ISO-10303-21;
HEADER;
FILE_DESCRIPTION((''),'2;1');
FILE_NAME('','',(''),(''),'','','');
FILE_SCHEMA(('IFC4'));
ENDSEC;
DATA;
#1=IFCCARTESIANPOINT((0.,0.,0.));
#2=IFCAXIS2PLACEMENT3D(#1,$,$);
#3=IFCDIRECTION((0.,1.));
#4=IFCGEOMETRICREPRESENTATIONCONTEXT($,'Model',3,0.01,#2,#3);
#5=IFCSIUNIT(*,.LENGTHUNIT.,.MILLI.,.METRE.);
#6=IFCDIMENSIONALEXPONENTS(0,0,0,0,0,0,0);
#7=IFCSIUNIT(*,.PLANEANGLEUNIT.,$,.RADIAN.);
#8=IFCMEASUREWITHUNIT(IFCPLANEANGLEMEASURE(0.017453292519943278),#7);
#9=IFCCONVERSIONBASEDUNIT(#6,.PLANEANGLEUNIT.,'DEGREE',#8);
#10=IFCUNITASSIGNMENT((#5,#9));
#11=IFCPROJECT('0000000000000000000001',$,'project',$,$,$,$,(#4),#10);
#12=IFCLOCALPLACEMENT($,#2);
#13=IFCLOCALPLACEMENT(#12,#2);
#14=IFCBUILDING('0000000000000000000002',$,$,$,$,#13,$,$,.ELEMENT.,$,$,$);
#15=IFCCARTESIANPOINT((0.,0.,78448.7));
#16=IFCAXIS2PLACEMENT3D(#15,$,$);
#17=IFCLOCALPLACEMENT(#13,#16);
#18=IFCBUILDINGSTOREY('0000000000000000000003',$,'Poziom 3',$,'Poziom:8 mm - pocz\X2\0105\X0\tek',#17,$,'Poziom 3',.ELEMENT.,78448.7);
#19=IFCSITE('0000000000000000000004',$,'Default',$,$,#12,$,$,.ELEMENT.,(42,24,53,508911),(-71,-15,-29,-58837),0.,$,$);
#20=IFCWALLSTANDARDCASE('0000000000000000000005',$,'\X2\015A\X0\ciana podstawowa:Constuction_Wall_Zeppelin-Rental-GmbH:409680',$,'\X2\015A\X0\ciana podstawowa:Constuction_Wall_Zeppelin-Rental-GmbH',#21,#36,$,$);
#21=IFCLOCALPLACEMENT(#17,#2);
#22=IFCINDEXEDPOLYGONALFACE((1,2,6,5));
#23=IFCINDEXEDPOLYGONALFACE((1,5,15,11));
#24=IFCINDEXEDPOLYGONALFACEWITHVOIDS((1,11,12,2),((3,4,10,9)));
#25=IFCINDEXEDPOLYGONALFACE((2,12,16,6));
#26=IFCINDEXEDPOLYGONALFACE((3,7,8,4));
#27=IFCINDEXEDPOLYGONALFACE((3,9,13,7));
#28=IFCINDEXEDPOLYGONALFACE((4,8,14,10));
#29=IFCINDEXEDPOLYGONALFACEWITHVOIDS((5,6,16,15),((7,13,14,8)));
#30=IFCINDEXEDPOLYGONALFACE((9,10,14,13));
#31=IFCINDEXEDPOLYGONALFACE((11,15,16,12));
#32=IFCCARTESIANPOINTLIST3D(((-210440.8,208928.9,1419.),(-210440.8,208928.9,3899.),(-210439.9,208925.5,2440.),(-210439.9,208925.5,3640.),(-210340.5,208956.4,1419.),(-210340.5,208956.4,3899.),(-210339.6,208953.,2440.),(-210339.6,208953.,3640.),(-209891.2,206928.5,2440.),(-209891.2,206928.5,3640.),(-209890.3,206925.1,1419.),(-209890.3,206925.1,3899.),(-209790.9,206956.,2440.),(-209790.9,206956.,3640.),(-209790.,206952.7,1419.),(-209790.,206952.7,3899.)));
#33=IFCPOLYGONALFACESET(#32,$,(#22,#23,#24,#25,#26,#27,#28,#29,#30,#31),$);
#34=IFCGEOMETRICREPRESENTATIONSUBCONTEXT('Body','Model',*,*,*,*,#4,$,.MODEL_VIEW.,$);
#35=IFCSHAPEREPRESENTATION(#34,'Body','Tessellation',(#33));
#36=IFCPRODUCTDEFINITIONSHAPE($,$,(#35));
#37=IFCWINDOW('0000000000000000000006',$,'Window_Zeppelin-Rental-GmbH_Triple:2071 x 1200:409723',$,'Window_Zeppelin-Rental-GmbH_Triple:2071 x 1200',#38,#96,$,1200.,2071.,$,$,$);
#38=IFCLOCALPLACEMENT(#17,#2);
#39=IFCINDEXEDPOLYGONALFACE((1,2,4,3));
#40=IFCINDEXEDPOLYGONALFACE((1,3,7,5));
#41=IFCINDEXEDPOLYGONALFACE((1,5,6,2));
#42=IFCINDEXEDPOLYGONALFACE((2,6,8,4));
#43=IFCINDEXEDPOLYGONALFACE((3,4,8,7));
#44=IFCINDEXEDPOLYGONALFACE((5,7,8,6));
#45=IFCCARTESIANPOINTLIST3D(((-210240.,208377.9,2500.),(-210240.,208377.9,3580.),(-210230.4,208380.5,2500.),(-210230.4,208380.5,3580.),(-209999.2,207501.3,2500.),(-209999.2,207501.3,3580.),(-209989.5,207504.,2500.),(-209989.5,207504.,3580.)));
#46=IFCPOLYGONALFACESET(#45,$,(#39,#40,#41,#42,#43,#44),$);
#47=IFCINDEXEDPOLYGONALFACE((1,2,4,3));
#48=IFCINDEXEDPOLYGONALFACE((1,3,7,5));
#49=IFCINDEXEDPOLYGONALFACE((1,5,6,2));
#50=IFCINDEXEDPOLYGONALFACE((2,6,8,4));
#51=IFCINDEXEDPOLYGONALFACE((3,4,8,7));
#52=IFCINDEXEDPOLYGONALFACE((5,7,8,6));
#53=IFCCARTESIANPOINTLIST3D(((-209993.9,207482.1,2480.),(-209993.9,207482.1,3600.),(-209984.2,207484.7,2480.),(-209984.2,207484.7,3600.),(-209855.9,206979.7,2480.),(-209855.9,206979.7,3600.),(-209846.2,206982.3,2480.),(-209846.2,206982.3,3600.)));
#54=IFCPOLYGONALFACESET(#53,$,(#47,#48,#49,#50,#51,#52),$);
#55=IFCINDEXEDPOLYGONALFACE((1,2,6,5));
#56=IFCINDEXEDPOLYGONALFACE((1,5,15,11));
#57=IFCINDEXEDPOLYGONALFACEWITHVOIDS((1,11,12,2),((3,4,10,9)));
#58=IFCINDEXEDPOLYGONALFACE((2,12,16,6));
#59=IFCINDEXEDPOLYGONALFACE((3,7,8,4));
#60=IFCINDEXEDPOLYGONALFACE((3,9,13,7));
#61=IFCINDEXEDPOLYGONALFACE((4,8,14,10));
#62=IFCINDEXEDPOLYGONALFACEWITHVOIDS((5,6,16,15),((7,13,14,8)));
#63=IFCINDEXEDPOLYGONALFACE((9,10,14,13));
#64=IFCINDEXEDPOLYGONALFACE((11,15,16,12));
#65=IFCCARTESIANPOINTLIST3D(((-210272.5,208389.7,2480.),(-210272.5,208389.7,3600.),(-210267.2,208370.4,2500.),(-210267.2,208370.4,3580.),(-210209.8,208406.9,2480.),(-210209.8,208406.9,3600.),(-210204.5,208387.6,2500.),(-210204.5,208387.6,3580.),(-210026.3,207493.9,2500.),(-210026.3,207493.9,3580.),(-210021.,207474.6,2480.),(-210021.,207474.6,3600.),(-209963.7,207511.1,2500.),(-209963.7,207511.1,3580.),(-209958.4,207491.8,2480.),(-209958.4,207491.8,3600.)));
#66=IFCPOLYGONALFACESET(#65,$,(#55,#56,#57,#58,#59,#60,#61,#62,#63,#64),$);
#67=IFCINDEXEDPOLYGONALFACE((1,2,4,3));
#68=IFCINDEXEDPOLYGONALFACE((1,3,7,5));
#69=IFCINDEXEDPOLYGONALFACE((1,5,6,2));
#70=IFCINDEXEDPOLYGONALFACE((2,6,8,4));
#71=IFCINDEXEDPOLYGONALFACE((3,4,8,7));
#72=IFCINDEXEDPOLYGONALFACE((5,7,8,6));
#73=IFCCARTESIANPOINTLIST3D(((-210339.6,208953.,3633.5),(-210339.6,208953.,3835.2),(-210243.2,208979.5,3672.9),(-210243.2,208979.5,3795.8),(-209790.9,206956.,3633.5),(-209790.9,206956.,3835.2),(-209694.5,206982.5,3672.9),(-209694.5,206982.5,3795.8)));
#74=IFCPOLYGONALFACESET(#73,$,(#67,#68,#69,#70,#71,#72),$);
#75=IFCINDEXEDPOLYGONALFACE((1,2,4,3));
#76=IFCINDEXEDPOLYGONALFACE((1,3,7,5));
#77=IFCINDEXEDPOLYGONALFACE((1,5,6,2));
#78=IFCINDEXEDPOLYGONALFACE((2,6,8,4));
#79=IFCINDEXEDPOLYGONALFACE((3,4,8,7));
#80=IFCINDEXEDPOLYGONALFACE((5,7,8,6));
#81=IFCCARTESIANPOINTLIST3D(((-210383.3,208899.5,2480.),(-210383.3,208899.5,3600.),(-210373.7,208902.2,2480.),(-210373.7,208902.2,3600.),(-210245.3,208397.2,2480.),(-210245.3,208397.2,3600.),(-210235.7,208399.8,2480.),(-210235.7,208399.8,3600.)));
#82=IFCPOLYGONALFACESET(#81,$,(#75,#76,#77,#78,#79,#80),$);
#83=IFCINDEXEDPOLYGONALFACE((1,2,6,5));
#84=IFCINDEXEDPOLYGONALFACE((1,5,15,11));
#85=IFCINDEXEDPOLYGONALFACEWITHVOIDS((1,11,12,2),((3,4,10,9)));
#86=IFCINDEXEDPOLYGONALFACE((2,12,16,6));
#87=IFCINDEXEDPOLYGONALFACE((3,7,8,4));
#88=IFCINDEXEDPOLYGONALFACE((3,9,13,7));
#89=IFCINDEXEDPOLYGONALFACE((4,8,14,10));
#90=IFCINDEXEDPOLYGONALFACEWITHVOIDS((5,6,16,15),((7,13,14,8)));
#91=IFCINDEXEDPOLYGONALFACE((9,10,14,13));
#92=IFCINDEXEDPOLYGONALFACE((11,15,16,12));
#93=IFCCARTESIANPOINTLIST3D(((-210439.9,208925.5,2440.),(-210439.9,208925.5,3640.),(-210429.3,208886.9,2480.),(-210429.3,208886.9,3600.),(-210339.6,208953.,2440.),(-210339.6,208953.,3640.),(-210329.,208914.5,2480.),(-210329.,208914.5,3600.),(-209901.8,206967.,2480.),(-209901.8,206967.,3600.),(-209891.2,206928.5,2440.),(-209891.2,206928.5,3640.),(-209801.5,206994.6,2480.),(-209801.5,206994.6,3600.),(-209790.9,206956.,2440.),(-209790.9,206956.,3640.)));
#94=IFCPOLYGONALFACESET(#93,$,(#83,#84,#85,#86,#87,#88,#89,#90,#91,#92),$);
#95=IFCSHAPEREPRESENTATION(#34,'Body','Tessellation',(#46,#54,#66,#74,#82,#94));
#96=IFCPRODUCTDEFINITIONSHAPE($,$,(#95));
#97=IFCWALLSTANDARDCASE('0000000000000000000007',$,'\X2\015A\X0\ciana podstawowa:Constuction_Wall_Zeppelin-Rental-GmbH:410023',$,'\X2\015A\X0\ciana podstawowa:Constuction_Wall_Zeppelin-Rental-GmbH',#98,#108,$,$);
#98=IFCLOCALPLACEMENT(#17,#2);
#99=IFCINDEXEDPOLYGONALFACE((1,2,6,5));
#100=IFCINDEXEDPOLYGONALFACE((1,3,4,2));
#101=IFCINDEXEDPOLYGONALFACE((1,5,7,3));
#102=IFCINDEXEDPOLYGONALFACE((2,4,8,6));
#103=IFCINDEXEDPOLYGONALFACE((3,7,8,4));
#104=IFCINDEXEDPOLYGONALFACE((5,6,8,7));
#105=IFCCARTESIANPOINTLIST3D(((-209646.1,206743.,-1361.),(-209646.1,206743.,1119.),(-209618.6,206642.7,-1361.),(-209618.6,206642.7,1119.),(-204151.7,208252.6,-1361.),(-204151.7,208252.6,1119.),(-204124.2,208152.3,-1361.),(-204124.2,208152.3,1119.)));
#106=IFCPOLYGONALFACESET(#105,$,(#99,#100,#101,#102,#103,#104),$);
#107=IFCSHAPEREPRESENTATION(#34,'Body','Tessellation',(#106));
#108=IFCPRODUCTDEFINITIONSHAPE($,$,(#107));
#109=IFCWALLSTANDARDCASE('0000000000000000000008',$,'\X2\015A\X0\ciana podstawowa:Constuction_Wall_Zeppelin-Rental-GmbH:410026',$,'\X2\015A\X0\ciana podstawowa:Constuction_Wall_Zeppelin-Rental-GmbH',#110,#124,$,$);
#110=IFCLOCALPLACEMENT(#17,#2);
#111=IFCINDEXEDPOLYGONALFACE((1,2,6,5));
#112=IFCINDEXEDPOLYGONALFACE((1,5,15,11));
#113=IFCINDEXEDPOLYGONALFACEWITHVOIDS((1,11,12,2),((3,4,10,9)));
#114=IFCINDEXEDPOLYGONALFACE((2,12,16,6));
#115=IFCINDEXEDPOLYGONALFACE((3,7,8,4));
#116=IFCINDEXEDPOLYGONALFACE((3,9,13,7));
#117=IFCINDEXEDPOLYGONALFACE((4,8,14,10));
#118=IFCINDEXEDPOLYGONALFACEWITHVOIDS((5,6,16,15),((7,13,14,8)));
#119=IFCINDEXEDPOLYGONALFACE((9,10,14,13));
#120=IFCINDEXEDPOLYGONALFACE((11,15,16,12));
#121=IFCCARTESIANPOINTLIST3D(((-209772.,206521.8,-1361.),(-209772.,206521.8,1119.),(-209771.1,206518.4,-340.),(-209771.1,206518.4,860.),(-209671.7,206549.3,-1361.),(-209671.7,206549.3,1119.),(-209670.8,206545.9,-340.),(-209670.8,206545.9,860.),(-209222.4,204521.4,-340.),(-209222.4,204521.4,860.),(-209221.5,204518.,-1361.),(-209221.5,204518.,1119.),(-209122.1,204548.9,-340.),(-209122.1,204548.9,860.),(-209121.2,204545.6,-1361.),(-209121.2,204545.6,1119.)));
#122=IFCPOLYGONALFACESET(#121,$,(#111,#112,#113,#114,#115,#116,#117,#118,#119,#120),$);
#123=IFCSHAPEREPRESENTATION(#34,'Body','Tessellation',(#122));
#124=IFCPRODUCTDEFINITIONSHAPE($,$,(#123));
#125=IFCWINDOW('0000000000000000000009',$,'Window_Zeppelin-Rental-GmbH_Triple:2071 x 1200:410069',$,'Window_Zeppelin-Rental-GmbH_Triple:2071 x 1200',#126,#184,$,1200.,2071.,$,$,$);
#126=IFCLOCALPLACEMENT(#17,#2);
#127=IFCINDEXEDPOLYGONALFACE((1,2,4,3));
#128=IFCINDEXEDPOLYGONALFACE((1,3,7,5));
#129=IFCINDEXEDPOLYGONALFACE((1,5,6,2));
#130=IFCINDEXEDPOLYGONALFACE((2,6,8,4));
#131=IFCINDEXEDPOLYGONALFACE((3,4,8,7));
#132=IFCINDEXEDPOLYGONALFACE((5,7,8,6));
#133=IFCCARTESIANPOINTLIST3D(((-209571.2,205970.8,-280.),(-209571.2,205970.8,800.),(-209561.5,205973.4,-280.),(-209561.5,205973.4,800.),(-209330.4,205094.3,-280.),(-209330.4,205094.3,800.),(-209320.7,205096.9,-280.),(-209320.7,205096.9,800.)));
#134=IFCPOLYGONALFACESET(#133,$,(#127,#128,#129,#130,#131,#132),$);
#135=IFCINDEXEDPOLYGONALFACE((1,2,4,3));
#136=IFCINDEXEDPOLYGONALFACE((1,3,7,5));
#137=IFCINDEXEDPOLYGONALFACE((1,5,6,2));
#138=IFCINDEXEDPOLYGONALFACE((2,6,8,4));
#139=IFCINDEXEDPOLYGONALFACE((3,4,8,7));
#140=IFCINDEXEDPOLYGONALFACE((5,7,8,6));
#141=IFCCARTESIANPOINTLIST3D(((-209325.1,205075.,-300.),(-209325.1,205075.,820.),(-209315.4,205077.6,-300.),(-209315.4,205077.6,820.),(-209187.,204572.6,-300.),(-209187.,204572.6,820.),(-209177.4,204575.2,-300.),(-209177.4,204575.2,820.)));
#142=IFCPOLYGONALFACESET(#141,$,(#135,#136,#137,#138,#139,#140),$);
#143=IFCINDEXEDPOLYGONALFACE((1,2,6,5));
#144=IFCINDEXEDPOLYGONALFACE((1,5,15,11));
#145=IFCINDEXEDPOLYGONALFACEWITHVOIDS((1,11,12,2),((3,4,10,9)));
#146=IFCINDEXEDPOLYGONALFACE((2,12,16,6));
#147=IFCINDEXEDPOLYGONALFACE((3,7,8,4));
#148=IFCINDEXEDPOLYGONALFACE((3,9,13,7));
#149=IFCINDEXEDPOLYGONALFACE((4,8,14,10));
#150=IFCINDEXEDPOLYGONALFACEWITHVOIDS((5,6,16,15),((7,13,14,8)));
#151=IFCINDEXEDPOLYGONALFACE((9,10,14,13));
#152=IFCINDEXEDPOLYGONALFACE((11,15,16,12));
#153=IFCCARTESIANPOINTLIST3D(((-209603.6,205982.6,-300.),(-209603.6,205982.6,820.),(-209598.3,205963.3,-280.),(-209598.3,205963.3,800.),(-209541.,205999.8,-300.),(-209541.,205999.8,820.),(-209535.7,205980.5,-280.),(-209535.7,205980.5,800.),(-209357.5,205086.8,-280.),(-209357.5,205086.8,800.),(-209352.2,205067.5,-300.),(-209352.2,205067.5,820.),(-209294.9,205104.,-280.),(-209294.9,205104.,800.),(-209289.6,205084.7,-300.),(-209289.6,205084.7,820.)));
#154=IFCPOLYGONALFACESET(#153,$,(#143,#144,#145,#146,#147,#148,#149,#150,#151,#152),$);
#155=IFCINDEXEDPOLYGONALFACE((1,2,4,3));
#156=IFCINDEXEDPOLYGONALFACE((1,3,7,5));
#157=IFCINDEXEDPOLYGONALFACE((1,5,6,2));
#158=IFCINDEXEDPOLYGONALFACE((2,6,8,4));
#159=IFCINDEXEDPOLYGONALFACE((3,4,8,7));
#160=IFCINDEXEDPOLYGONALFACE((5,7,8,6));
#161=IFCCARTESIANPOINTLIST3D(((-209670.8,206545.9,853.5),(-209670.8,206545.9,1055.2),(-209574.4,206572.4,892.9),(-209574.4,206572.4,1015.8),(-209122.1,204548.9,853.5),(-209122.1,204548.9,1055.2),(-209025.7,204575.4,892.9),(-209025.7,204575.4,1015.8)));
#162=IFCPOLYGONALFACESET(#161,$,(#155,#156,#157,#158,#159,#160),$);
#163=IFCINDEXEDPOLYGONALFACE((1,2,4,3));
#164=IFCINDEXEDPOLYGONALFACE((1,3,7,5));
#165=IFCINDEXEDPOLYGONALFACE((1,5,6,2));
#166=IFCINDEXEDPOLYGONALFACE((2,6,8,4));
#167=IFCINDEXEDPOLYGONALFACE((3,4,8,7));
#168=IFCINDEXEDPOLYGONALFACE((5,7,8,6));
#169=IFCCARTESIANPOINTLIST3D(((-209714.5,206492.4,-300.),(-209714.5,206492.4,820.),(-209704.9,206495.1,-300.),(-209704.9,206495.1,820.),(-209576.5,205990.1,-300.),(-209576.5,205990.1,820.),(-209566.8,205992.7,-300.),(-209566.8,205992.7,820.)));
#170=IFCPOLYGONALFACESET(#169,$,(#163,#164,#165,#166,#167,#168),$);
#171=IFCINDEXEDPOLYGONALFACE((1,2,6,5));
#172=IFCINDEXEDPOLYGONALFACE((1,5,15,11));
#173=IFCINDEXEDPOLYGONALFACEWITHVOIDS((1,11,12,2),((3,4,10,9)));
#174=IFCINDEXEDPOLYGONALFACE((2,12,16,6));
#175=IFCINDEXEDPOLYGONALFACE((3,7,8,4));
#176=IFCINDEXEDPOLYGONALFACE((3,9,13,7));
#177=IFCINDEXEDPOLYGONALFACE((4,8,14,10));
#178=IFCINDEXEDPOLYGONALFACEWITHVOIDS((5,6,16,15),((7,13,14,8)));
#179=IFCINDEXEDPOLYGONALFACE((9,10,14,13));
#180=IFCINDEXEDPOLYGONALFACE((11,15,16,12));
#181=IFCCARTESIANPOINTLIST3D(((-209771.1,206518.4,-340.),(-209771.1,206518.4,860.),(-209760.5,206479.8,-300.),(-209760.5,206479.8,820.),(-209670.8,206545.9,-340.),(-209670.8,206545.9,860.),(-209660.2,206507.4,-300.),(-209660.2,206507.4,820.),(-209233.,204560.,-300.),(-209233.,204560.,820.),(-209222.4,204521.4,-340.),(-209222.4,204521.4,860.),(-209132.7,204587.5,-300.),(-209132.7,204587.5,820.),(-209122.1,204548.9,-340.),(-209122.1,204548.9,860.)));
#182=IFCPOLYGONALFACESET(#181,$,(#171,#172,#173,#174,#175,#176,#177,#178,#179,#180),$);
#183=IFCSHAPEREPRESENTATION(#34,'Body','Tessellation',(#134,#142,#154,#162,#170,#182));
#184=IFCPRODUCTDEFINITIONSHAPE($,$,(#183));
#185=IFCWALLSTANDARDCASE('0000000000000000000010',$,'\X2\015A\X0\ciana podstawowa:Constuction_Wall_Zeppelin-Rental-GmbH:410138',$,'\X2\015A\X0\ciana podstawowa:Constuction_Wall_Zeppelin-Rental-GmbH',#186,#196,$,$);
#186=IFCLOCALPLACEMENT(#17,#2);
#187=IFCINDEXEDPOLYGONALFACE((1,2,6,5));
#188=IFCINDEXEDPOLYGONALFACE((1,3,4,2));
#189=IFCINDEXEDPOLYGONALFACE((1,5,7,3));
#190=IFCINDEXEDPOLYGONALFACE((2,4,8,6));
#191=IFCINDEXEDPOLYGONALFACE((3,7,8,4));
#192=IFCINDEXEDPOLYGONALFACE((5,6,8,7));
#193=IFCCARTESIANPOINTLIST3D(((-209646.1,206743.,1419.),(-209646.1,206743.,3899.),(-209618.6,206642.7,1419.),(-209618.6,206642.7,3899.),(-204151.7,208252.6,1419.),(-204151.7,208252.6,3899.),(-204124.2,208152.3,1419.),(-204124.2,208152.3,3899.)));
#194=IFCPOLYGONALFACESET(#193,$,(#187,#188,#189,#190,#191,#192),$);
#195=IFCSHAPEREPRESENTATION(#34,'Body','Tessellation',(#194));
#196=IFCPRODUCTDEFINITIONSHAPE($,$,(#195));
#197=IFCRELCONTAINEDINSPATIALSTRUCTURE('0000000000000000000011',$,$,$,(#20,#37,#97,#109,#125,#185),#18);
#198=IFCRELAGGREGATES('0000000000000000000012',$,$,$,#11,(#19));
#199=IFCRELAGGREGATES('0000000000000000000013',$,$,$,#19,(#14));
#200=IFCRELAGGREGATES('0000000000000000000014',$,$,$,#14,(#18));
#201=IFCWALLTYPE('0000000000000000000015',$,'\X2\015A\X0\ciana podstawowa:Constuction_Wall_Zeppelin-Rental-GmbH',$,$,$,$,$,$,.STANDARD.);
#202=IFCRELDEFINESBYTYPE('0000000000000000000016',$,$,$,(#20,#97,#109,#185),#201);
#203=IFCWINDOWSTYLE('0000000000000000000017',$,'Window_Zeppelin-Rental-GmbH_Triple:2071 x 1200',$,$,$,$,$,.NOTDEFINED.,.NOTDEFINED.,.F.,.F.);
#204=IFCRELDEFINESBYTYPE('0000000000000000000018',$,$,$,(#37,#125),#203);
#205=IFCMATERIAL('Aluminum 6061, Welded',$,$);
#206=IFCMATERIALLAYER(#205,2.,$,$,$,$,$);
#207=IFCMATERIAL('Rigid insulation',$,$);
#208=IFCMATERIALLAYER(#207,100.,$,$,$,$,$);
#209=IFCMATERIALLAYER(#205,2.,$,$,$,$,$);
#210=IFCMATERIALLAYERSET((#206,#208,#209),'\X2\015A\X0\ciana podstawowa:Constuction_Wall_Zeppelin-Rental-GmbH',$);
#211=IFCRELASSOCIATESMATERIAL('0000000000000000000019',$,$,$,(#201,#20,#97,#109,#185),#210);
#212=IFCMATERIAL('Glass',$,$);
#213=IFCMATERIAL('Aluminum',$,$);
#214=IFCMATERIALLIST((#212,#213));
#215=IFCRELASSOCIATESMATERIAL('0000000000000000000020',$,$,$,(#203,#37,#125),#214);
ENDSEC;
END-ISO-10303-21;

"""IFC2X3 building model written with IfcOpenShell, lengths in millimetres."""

from ifc_helpers import new_model, entity, si_unit, converted_unit, direction, frame, frame_2d, origin, origin_2d_with_axis, place, context, subcontext, project, spatial, polyline, rectangle, outline, extrude, source, transform, mapped, material, material_list, layer, layer_set, layer_usage, type_object, type_shapes, element, fill, save


model = new_model("IFC2X3")

# Units and contexts
model_context = context("Model", 3, precision=0.01, world=origin(), true_north=direction((0.0, 1.0)))
body_context = subcontext(model_context, "Body", "Model", "MODEL_VIEW")
ifc_project = project(units=[si_unit("LENGTHUNIT", "METRE", prefix="MILLI"), converted_unit("PLANEANGLEUNIT", "DEGREE", entity("IfcPlaneAngleMeasure", 0.017453292519943278), si_unit("PLANEANGLEUNIT", "RADIAN"), dimensions=[0, 0, 0, 0, 0, 0, 0])], contexts=[model_context])

# Site, building, storey
site_placement = place(None, origin())
site = spatial("IfcSite", under=ifc_project, at=site_placement, Name="Default", CompositionType="ELEMENT", RefLatitude=(42, 24, 53, 508911), RefLongitude=(-71, -15, -29, -58837), RefElevation=0.0)
building_placement = place(site_placement, origin())
building = spatial("IfcBuilding", under=site, at=building_placement, CompositionType="ELEMENT")
storey_placement = place(building_placement, frame((0.0, 0.0, 78448.7)))
storey = spatial("IfcBuildingStorey", under=building, at=storey_placement, Name="Poziom 3", ObjectType="Poziom:8 mm - początek", LongName="Poziom 3", CompositionType="ELEMENT", Elevation=78448.7)

# Shared definitions
ifc_material_1 = material(Name="Aluminum 6061, Welded")
ifc_layer_1 = layer(ifc_material_1, 2.0)
ifc_material_2 = material(Name="Rigid insulation")
ifc_layer_2 = layer(ifc_material_2, 100.0)
ifc_layer_3 = layer(ifc_material_1, 2.0)
ifc_layer_set_1 = layer_set([ifc_layer_1, ifc_layer_2, ifc_layer_3], Name="Ściana podstawowa:Constuction_Wall_Zeppelin-Rental-GmbH")
wall_type_1 = type_object("IfcWallType", Name="Ściana podstawowa:Constuction_Wall_Zeppelin-Rental-GmbH", PredefinedType="STANDARD", material=ifc_layer_set_1)

# Shared definitions
ifc_material_3 = material(Name="Glass")
ifc_material_4 = material(Name="Aluminum")
ifc_material_list = material_list([ifc_material_3, ifc_material_4])
window_style = type_object("IfcWindowStyle", Name="Window_Zeppelin-Rental-GmbH_Triple:2071 x 1200", ConstructionType="NOTDEFINED", OperationType="NOTDEFINED", ParameterTakesPrecedence=False, Sizeable=False, material=ifc_material_list)
shared_shape_1 = source(origin(), body_context, "Body", "SweptSolid", [
    extrude(rectangle(XDim=10.0, YDim=909.0, at=origin_2d_with_axis()), frame((1035.5, 52.7, 60.0), z_axis=(0.0, 0.0, 1.0), x_axis=(0.0, -1.0, 0.0)), (0.0, 0.0, 1.0), 1080.0),
    extrude(rectangle(XDim=521.0, YDim=10.0, at=frame_2d((0.0, 0.0), x_axis=(1.0, 0.0))), frame((300.5, 52.7, 40.0), z_axis=(0.0, 0.0, 1.0), x_axis=(-1.0, 0.0, 0.0)), (0.0, 0.0, 1.0), 1120.0),
    extrude(outline(polyline([(-474.5, -560.0), (474.5, -560.0), (474.5, 560.0), (-474.5, 560.0), (-474.5, -560.0)]), holes=[polyline([(-454.5, 540.0), (454.5, 540.0), (454.5, -540.0), (-454.5, -540.0), (-454.5, 540.0)])]), frame((1035.5, 85.8, 600.0), z_axis=(0.0, -1.0, 0.0), x_axis=(1.0, 0.0, 0.0)), (0.0, 0.0, 1.0), 65.0),
    extrude(outline(polyline([(-24.0, -75.5), (83.5, -75.5), (9.6, 112.1), (-69.0, 38.9), (-24.0, -75.5)])), frame((2071.0, -48.7, 1294.4), z_axis=(-1.0, 0.0, 0.0), x_axis=(0.0, 0.930458, 0.366398)), (0.0, 0.0, 1.0), 2071.0),
    extrude(rectangle(XDim=10.0, YDim=521.0, at=frame_2d((0.0, 0.0), x_axis=(1.0, 0.0))), frame((1770.5, 52.7, 40.0), z_axis=(0.0, 0.0, 1.0), x_axis=(0.0, -1.0, 0.0)), (0.0, 0.0, 1.0), 1120.0),
    extrude(outline(polyline([(-1035.5, -600.0), (1035.5, -600.0), (1035.5, 600.0), (-1035.5, 600.0), (-1035.5, -600.0)]), holes=[polyline([(-995.5, 560.0), (995.5, 560.0), (995.5, -560.0), (-995.5, -560.0), (-995.5, 560.0)])]), frame((1035.5, 105.3, 600.0), z_axis=(0.0, -1.0, 0.0), x_axis=(1.0, 0.0, 0.0)), (0.0, 0.0, 1.0), 104.0),
])
type_shapes(window_style, [shared_shape_1])

# Wall, opening, window
ifc_layer_usage_1 = layer_usage(ifc_layer_set_1, "AXIS2", "NEGATIVE", 52.0)
wall_1_placement = place(storey_placement, frame((-209840.2, 206938.9, 1419.0), z_axis=(0.0, 0.0, 1.0), x_axis=(-0.264931, 0.964267, 0.0)))
wall_1 = element("IfcWallStandardCase", 1, at=wall_1_placement, inside=storey, type_object=wall_type_1, material=ifc_layer_usage_1, Name="Ściana podstawowa:Constuction_Wall_Zeppelin-Rental-GmbH:409680", ObjectType="Ściana podstawowa:Constuction_Wall_Zeppelin-Rental-GmbH", context=body_context, shape_type="SweptSolid", body=[
    extrude(rectangle(XDim=2078.0, YDim=104.0, at=frame_2d((1039.0, 0.0), x_axis=(-1.0, 0.0))), origin(), (0.0, 0.0, 1.0), 2480.0),
])
opening_1_placement = place(wall_1_placement, frame((3.5, -52.0, 1021.0)))
opening_1 = element("IfcOpeningElement", 2, at=opening_1_placement, cuts=wall_1, ObjectType="Opening", context=body_context, shape_type="SweptSolid", body=[
    extrude(rectangle(XDim=1200.0, YDim=2071.0, at=frame_2d((600.0, 1035.5), x_axis=(1.0, 0.0))), frame((0.0, 0.0, 0.0), z_axis=(0.0, 1.0, 0.0), x_axis=(0.0, 0.0, 1.0)), (0.0, 0.0, 1.0), 104.0),
])
window_1_placement = place(opening_1_placement, frame((0.0, -1.3, 0.0)))
window_1 = element("IfcWindow", 3, at=window_1_placement, inside=storey, type_object=window_style, material=ifc_material_list, Name="Window_Zeppelin-Rental-GmbH_Triple:2071 x 1200:409723", ObjectType="Window_Zeppelin-Rental-GmbH_Triple:2071 x 1200", OverallHeight=1200.0, OverallWidth=2071.0, context=body_context, shape_type="MappedRepresentation", body=[
    mapped(shared_shape_1, transform((0.0, 0.0, 0.0), scale=1.0)),
])
fill(opening_1, window_1)

# Wall
ifc_layer_usage_2 = layer_usage(ifc_layer_set_1, "AXIS2", "NEGATIVE", 52.0)
wall_2_placement = place(storey_placement, frame((-209632.3, 206692.9, -1361.0), z_axis=(0.0, 0.0, 1.0), x_axis=(0.964267, 0.264931, 0.0)))
element("IfcWallStandardCase", 4, at=wall_2_placement, inside=storey, type_object=wall_type_1, material=ifc_layer_usage_2, Name="Ściana podstawowa:Constuction_Wall_Zeppelin-Rental-GmbH:410023", ObjectType="Ściana podstawowa:Constuction_Wall_Zeppelin-Rental-GmbH", context=body_context, shape_type="SweptSolid", body=[
    extrude(rectangle(XDim=5698.0, YDim=104.0, at=frame_2d((2849.0, 0.0), x_axis=(-1.0, 0.0))), origin(), (0.0, 0.0, 1.0), 2480.0),
])

# Wall, opening, window
ifc_layer_usage_3 = layer_usage(ifc_layer_set_1, "AXIS2", "NEGATIVE", 52.0)
wall_3_placement = place(storey_placement, frame((-209171.3, 204531.8, -1361.0), z_axis=(0.0, 0.0, 1.0), x_axis=(-0.264931, 0.964267, 0.0)))
wall_3 = element("IfcWallStandardCase", 5, at=wall_3_placement, inside=storey, type_object=wall_type_1, material=ifc_layer_usage_3, Name="Ściana podstawowa:Constuction_Wall_Zeppelin-Rental-GmbH:410026", ObjectType="Ściana podstawowa:Constuction_Wall_Zeppelin-Rental-GmbH", context=body_context, shape_type="SweptSolid", body=[
    extrude(rectangle(XDim=2078.0, YDim=104.0, at=frame_2d((1039.0, 0.0), x_axis=(-1.0, 0.0))), origin(), (0.0, 0.0, 1.0), 2480.0),
])
opening_2_placement = place(wall_3_placement, frame((3.5, -52.0, 1021.0)))
opening_2 = element("IfcOpeningElement", 6, at=opening_2_placement, cuts=wall_3, ObjectType="Opening", context=body_context, shape_type="SweptSolid", body=[
    extrude(rectangle(XDim=1200.0, YDim=2071.0, at=frame_2d((600.0, 1035.5), x_axis=(1.0, 0.0))), frame((0.0, 0.0, 0.0), z_axis=(0.0, 1.0, 0.0), x_axis=(0.0, 0.0, 1.0)), (0.0, 0.0, 1.0), 104.0),
])
window_2_placement = place(opening_2_placement, frame((0.0, -1.3, 0.0)))
window_2 = element("IfcWindow", 7, at=window_2_placement, inside=storey, type_object=window_style, material=ifc_material_list, Name="Window_Zeppelin-Rental-GmbH_Triple:2071 x 1200:410069", ObjectType="Window_Zeppelin-Rental-GmbH_Triple:2071 x 1200", OverallHeight=1200.0, OverallWidth=2071.0, context=body_context, shape_type="MappedRepresentation", body=[
    mapped(shared_shape_1, transform((0.0, 0.0, 0.0), scale=1.0)),
])
fill(opening_2, window_2)

# Wall
ifc_layer_usage_4 = layer_usage(ifc_layer_set_1, "AXIS2", "NEGATIVE", 52.0)
wall_4_placement = place(storey_placement, frame((-209632.3, 206692.9, 1419.0), z_axis=(0.0, 0.0, 1.0), x_axis=(0.964267, 0.264931, 0.0)))
element("IfcWallStandardCase", 8, at=wall_4_placement, inside=storey, type_object=wall_type_1, material=ifc_layer_usage_4, Name="Ściana podstawowa:Constuction_Wall_Zeppelin-Rental-GmbH:410138", ObjectType="Ściana podstawowa:Constuction_Wall_Zeppelin-Rental-GmbH", context=body_context, shape_type="SweptSolid", body=[
    extrude(rectangle(XDim=5698.0, YDim=104.0, at=frame_2d((2849.0, 0.0), x_axis=(-1.0, 0.0))), origin(), (0.0, 0.0, 1.0), 2480.0),
])

save(model, "model.ifc")
